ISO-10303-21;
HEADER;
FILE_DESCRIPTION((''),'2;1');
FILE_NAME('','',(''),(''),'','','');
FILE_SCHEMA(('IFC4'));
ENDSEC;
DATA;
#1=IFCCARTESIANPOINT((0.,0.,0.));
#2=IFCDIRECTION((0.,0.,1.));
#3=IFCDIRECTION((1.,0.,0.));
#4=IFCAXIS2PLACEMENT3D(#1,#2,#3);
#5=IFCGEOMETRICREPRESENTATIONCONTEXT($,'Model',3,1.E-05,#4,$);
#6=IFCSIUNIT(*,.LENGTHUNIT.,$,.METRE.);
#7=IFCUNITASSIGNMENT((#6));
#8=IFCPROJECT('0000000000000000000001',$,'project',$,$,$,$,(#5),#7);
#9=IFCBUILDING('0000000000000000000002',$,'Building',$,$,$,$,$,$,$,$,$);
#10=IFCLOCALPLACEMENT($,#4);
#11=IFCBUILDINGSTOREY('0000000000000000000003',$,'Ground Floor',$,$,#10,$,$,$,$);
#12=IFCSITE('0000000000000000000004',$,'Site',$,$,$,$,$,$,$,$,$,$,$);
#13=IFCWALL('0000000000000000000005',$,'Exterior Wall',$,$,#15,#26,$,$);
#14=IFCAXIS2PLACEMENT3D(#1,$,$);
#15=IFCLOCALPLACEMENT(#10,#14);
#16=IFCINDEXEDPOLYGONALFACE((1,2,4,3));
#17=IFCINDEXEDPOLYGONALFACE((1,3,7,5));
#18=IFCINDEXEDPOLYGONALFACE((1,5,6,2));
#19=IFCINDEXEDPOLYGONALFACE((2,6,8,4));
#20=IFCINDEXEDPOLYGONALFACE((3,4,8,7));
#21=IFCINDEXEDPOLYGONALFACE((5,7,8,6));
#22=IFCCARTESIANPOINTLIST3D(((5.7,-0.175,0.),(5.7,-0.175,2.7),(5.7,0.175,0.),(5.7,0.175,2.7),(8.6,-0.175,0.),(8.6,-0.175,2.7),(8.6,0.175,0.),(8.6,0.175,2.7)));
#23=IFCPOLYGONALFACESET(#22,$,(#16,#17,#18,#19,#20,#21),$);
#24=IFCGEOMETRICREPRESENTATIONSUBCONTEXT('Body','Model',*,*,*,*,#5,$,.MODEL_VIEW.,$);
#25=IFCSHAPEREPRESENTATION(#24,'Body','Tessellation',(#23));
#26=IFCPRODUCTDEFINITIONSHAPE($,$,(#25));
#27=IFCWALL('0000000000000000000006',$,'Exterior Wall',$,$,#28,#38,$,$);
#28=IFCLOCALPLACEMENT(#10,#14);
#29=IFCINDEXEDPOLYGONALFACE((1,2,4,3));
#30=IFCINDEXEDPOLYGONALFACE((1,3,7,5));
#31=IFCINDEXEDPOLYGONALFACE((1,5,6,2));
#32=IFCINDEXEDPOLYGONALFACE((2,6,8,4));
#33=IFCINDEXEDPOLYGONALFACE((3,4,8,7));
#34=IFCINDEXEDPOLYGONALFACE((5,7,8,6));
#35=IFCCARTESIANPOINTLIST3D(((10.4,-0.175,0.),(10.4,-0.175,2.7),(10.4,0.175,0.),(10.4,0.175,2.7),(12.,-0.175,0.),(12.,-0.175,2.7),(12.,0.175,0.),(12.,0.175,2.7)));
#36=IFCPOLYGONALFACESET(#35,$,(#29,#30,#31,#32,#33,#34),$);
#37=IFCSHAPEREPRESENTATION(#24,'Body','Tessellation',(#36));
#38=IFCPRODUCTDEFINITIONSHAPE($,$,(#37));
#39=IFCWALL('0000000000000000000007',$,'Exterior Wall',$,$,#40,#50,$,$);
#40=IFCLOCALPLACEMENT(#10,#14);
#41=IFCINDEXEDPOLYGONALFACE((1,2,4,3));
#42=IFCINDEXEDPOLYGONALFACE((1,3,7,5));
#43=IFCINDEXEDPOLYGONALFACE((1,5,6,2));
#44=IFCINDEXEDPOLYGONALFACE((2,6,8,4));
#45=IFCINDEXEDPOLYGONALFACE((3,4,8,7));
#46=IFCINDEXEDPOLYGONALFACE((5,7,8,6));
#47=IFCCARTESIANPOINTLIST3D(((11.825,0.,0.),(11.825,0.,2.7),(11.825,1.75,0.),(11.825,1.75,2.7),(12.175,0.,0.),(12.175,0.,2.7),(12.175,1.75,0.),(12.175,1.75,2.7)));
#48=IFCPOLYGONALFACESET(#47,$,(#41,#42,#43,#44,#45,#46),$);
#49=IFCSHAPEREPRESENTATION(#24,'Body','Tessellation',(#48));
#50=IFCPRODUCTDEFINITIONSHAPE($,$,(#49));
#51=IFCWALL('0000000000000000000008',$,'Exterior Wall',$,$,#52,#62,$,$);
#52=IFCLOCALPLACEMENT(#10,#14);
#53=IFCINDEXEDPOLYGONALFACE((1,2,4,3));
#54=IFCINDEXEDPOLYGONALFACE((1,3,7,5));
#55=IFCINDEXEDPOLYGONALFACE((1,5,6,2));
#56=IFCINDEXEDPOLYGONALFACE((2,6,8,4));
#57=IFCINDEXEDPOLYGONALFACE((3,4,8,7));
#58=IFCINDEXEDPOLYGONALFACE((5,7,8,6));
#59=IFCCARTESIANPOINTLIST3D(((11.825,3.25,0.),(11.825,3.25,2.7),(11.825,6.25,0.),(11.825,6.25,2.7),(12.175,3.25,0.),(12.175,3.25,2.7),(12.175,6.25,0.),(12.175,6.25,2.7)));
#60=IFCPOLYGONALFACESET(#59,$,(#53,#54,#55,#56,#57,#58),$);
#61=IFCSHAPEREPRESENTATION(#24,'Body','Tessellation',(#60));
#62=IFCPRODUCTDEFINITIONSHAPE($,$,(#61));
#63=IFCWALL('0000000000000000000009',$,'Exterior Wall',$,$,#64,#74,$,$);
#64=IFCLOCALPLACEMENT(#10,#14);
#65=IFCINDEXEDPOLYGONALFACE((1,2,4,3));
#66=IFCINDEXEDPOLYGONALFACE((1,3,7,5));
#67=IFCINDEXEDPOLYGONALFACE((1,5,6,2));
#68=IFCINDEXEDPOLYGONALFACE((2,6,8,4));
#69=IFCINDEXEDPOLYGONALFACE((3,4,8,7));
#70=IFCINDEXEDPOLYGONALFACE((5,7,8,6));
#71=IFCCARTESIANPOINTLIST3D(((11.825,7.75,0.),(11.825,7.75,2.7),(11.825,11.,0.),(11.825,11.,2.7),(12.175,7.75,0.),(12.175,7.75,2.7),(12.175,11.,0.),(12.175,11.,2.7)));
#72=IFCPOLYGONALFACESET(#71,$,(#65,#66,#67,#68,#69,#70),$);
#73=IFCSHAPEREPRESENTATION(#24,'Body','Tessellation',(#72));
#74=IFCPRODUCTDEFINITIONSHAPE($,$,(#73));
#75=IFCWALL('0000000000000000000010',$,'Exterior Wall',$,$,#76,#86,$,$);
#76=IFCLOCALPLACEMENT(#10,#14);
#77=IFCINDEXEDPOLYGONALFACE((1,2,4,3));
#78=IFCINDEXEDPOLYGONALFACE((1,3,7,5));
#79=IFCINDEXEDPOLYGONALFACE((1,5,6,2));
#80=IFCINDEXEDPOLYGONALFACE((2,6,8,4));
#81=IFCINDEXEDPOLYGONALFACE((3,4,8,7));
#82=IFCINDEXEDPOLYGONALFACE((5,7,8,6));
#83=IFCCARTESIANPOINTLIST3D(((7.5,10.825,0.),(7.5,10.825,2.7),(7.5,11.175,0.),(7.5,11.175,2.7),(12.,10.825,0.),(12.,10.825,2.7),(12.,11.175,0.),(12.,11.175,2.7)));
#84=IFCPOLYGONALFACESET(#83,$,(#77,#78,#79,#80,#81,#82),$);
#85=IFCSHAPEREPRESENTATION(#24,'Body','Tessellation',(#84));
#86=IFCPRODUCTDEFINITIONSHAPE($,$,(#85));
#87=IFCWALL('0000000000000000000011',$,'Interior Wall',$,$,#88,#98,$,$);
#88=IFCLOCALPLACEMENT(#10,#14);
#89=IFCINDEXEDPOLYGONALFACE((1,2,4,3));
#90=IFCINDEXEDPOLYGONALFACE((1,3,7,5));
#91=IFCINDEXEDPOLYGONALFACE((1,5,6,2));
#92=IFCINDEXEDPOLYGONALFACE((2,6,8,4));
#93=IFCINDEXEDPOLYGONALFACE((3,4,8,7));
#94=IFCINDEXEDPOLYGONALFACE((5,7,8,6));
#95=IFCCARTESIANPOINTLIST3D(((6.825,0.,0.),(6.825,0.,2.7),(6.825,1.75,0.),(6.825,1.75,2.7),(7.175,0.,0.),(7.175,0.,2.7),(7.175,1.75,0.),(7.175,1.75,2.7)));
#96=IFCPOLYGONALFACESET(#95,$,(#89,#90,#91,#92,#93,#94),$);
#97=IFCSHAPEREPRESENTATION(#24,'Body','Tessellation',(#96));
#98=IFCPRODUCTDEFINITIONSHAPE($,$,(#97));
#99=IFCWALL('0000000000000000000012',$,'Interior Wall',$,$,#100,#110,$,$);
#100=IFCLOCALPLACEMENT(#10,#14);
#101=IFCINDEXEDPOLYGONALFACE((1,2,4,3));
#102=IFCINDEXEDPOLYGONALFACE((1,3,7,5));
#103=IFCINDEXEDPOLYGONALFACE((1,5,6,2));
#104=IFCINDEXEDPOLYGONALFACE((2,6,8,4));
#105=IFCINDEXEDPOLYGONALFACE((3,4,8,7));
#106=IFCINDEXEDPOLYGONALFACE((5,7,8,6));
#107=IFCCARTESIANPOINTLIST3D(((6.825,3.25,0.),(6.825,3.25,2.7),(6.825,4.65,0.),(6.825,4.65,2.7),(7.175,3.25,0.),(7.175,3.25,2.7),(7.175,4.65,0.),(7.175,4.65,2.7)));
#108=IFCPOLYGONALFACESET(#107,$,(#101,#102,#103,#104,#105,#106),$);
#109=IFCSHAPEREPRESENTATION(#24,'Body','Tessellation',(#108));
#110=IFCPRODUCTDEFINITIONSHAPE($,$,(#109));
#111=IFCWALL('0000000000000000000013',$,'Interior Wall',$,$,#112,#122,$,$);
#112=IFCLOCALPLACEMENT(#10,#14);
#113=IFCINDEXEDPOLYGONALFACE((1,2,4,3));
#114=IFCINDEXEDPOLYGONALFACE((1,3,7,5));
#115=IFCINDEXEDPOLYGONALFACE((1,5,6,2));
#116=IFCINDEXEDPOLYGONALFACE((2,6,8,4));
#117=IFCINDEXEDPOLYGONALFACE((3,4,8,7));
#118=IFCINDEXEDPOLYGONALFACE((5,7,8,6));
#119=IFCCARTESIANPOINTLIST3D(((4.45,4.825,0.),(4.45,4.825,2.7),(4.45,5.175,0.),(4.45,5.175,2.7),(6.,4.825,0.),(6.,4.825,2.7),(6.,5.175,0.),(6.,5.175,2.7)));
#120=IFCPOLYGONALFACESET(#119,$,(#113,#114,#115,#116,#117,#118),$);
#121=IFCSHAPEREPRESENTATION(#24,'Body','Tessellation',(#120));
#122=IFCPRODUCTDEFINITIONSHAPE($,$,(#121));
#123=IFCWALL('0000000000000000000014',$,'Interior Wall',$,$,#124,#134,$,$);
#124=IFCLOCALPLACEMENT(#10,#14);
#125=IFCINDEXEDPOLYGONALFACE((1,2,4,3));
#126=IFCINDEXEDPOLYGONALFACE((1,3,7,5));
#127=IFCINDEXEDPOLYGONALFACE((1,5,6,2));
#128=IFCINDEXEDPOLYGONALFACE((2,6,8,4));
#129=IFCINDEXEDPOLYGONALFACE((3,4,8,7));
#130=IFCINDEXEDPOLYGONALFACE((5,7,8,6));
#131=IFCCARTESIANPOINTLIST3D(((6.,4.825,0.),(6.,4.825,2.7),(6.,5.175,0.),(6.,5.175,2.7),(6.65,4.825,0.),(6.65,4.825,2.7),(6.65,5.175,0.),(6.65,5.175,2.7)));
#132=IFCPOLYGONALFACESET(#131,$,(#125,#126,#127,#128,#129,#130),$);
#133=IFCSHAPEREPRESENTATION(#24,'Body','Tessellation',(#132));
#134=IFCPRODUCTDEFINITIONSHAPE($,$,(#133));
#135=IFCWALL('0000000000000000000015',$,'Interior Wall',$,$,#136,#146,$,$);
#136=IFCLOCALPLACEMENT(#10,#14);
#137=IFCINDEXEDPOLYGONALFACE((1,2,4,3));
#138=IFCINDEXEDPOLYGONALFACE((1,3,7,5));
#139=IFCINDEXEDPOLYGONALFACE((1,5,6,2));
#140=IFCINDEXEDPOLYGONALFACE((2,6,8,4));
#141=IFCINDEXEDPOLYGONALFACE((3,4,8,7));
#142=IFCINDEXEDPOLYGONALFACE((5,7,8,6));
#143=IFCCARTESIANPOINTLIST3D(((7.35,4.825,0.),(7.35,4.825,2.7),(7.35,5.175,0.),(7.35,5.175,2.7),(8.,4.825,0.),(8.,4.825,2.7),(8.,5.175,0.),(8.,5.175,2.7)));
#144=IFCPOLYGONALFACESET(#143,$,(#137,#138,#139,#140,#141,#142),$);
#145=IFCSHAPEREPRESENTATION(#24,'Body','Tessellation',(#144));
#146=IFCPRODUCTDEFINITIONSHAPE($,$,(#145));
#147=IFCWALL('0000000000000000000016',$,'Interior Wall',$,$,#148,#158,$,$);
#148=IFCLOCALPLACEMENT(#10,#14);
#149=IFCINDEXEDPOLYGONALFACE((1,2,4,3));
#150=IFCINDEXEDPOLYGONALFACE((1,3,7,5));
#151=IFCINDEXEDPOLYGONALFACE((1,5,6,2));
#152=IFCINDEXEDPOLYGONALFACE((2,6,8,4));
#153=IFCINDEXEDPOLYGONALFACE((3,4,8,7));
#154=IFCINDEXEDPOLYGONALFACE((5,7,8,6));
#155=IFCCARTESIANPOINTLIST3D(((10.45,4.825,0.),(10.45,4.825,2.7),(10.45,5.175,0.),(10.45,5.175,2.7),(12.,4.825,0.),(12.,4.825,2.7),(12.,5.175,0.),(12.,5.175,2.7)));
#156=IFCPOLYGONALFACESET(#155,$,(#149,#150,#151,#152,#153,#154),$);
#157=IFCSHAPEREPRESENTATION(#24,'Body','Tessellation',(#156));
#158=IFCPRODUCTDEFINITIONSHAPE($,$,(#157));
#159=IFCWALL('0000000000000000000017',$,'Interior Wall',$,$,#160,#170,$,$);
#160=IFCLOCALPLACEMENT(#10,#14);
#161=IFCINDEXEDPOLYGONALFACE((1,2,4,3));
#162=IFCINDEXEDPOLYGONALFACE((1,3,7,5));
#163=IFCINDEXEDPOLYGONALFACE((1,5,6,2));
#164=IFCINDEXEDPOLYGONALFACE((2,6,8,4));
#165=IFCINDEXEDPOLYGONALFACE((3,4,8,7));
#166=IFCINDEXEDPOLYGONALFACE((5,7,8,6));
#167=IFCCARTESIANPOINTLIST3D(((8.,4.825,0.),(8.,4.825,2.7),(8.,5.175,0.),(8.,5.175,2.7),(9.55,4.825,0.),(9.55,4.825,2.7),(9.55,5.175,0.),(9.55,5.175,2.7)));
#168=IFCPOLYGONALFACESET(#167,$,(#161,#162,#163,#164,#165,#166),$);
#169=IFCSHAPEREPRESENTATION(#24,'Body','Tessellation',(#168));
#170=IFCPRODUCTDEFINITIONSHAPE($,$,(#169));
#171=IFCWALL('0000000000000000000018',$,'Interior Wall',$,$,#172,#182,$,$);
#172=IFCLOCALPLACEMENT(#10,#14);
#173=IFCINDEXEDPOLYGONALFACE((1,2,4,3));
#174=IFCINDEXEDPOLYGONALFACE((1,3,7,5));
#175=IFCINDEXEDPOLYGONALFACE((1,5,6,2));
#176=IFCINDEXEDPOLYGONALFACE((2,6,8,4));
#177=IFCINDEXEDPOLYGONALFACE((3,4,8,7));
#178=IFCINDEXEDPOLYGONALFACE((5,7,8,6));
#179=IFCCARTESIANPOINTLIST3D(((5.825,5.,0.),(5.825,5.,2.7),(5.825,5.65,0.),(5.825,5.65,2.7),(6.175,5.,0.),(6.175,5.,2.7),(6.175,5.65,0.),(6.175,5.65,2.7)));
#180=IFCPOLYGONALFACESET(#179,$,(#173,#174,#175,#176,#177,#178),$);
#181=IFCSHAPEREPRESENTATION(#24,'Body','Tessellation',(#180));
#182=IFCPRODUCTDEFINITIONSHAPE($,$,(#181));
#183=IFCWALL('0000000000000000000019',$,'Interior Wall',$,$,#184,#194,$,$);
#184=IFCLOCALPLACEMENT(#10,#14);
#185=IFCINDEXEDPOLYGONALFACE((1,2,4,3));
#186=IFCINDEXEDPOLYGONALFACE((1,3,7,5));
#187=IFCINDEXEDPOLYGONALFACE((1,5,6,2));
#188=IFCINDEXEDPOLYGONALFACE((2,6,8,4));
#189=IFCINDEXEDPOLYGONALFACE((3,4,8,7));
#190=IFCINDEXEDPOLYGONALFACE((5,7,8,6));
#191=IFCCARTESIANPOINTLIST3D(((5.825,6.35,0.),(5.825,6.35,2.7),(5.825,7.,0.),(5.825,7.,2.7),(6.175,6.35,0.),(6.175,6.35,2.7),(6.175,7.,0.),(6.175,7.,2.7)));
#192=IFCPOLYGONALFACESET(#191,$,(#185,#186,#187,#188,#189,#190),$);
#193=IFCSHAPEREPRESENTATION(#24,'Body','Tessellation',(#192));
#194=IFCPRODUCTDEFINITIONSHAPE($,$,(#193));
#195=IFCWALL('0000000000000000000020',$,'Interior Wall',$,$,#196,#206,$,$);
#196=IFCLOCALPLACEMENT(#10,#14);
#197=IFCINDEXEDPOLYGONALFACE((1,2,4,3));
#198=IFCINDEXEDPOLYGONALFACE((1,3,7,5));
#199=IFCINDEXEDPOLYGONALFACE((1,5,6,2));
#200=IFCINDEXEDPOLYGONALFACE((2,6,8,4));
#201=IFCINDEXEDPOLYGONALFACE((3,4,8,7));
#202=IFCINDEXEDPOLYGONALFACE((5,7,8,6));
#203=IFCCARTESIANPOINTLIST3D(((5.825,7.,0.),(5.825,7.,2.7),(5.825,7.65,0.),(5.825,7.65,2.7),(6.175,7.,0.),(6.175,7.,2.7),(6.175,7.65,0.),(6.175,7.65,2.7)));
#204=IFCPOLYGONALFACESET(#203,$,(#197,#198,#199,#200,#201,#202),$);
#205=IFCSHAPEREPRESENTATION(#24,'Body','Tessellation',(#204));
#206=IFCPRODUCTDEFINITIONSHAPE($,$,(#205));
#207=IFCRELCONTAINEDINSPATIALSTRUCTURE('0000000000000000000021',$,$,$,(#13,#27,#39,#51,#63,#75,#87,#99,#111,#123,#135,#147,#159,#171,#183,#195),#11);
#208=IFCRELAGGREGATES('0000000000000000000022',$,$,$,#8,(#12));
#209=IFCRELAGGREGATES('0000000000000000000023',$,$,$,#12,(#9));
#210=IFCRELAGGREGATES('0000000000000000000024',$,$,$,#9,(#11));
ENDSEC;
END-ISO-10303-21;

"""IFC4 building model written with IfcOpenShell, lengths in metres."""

from ifc_helpers import new_model, si_unit, frame, origin_with_axes, place, context, subcontext, project, spatial, indexed_curve, outline, extrude, element, save


model = new_model("IFC4")

# Units and contexts
model_context = context("Model", 3, precision=1e-05, world=origin_with_axes())
body_context = subcontext(model_context, "Body", "Model", "MODEL_VIEW")
ifc_project = project(units=[si_unit("LENGTHUNIT", "METRE")], contexts=[model_context])

# Site, building, storey
site = spatial("IfcSite", under=ifc_project, Name="Site")
building = spatial("IfcBuilding", under=site, Name="Building")
storey_placement = place(None, origin_with_axes())
storey = spatial("IfcBuildingStorey", under=building, at=storey_placement, Name="Ground Floor")

# Walls
wall_1_placement = place(storey_placement, frame((5.7, 0.0, 0.0), z_axis=(0.0, 0.0, 1.0), x_axis=(1.0, 0.0, 0.0)))
element("IfcWall", 1, at=wall_1_placement, inside=storey, Name="Exterior Wall", context=body_context, shape_type="SweptSolid", body=[
    extrude(outline(indexed_curve([(0.0, 0.0), (0.0, 0.35), (2.9, 0.35), (2.9, 0.0), (0.0, 0.0)], self_intersect=False)), frame((0.0, -0.175, 0.0), z_axis=(0.0, 0.0, 1.0), x_axis=(1.0, 0.0, 0.0)), (0.0, 0.0, 1.0), 2.7),
])
wall_2_placement = place(storey_placement, frame((10.4, 0.0, 0.0), z_axis=(0.0, 0.0, 1.0), x_axis=(1.0, 0.0, 0.0)))
element("IfcWall", 2, at=wall_2_placement, inside=storey, Name="Exterior Wall", context=body_context, shape_type="SweptSolid", body=[
    extrude(outline(indexed_curve([(0.0, 0.0), (0.0, 0.35), (1.6, 0.35), (1.6, 0.0), (0.0, 0.0)], self_intersect=False)), frame((0.0, -0.175, 0.0), z_axis=(0.0, 0.0, 1.0), x_axis=(1.0, 0.0, 0.0)), (0.0, 0.0, 1.0), 2.7),
])
wall_3_placement = place(storey_placement, frame((12.0, 0.0, 0.0), z_axis=(0.0, 0.0, 1.0), x_axis=(0.0, 1.0, 0.0)))
element("IfcWall", 3, at=wall_3_placement, inside=storey, Name="Exterior Wall", context=body_context, shape_type="SweptSolid", body=[
    extrude(outline(indexed_curve([(0.0, 0.0), (0.0, 0.35), (1.75, 0.35), (1.75, 0.0), (0.0, 0.0)], self_intersect=False)), frame((0.0, -0.175, 0.0), z_axis=(0.0, 0.0, 1.0), x_axis=(1.0, 0.0, 0.0)), (0.0, 0.0, 1.0), 2.7),
])
wall_4_placement = place(storey_placement, frame((12.0, 3.25, 0.0), z_axis=(0.0, 0.0, 1.0), x_axis=(0.0, 1.0, 0.0)))
element("IfcWall", 4, at=wall_4_placement, inside=storey, Name="Exterior Wall", context=body_context, shape_type="SweptSolid", body=[
    extrude(outline(indexed_curve([(0.0, 0.0), (0.0, 0.35), (3.0, 0.35), (3.0, 0.0), (0.0, 0.0)], self_intersect=False)), frame((0.0, -0.175, 0.0), z_axis=(0.0, 0.0, 1.0), x_axis=(1.0, 0.0, 0.0)), (0.0, 0.0, 1.0), 2.7),
])
wall_5_placement = place(storey_placement, frame((12.0, 7.75, 0.0), z_axis=(0.0, 0.0, 1.0), x_axis=(0.0, 1.0, 0.0)))
element("IfcWall", 5, at=wall_5_placement, inside=storey, Name="Exterior Wall", context=body_context, shape_type="SweptSolid", body=[
    extrude(outline(indexed_curve([(0.0, 0.0), (0.0, 0.35), (3.25, 0.35), (3.25, 0.0), (0.0, 0.0)], self_intersect=False)), frame((0.0, -0.175, 0.0), z_axis=(0.0, 0.0, 1.0), x_axis=(1.0, 0.0, 0.0)), (0.0, 0.0, 1.0), 2.7),
])
wall_6_placement = place(storey_placement, frame((12.0, 11.0, 0.0), z_axis=(0.0, 0.0, 1.0), x_axis=(-1.0, 0.0, 0.0)))
element("IfcWall", 6, at=wall_6_placement, inside=storey, Name="Exterior Wall", context=body_context, shape_type="SweptSolid", body=[
    extrude(outline(indexed_curve([(0.0, 0.0), (0.0, 0.35), (4.5, 0.35), (4.5, 0.0), (0.0, 0.0)], self_intersect=False)), frame((0.0, -0.175, 0.0), z_axis=(0.0, 0.0, 1.0), x_axis=(1.0, 0.0, 0.0)), (0.0, 0.0, 1.0), 2.7),
])
wall_7_placement = place(storey_placement, frame((7.0, 0.0, 0.0), z_axis=(0.0, 0.0, 1.0), x_axis=(0.0, 1.0, 0.0)))
element("IfcWall", 7, at=wall_7_placement, inside=storey, Name="Interior Wall", context=body_context, shape_type="SweptSolid", body=[
    extrude(outline(indexed_curve([(0.0, 0.0), (0.0, 0.35), (1.75, 0.35), (1.75, 0.0), (0.0, 0.0)], self_intersect=False)), frame((0.0, -0.175, 0.0), z_axis=(0.0, 0.0, 1.0), x_axis=(1.0, 0.0, 0.0)), (0.0, 0.0, 1.0), 2.7),
])
wall_8_placement = place(storey_placement, frame((7.0, 3.25, 0.0), z_axis=(0.0, 0.0, 1.0), x_axis=(0.0, 1.0, 0.0)))
element("IfcWall", 8, at=wall_8_placement, inside=storey, Name="Interior Wall", context=body_context, shape_type="SweptSolid", body=[
    extrude(outline(indexed_curve([(0.0, 0.0), (0.0, 0.35), (1.4, 0.35), (1.4, 0.0), (0.0, 0.0)], self_intersect=False)), frame((0.0, -0.175, 0.0), z_axis=(0.0, 0.0, 1.0), x_axis=(1.0, 0.0, 0.0)), (0.0, 0.0, 1.0), 2.7),
])
wall_9_placement = place(storey_placement, frame((6.0, 5.0, 0.0), z_axis=(0.0, 0.0, 1.0), x_axis=(-1.0, 0.0, 0.0)))
element("IfcWall", 9, at=wall_9_placement, inside=storey, Name="Interior Wall", context=body_context, shape_type="SweptSolid", body=[
    extrude(outline(indexed_curve([(0.0, 0.0), (0.0, 0.35), (1.55, 0.35), (1.55, 0.0), (0.0, 0.0)], self_intersect=False)), frame((0.0, -0.175, 0.0), z_axis=(0.0, 0.0, 1.0), x_axis=(1.0, 0.0, 0.0)), (0.0, 0.0, 1.0), 2.7),
])
for number, where, z_axis, x_axis, name in (
    (10, (6.65, 5.0, 0.0), (0.0, 0.0, 1.0), (-1.0, 0.0, 0.0), "Interior Wall"),
    (11, (8.0, 5.0, 0.0), (0.0, 0.0, 1.0), (-1.0, 0.0, 0.0), "Interior Wall"),
):
    element("IfcWall", number, at=place(storey_placement, frame(where, z_axis=z_axis, x_axis=x_axis)), inside=storey, Name=name, context=body_context, shape_type="SweptSolid", body=[
        extrude(outline(indexed_curve([(0.0, 0.0), (0.0, 0.35), (0.65, 0.35), (0.65, 0.0), (0.0, 0.0)], self_intersect=False)), frame((0.0, -0.175, 0.0), z_axis=(0.0, 0.0, 1.0), x_axis=(1.0, 0.0, 0.0)), (0.0, 0.0, 1.0), 2.7),
    ])
for number, where, z_axis, x_axis, name in (
    (12, (12.0, 5.0, 0.0), (0.0, 0.0, 1.0), (-1.0, 0.0, 0.0), "Interior Wall"),
    (13, (9.55, 5.0, 0.0), (0.0, 0.0, 1.0), (-1.0, 0.0, 0.0), "Interior Wall"),
):
    element("IfcWall", number, at=place(storey_placement, frame(where, z_axis=z_axis, x_axis=x_axis)), inside=storey, Name=name, context=body_context, shape_type="SweptSolid", body=[
        extrude(outline(indexed_curve([(0.0, 0.0), (0.0, 0.35), (1.55, 0.35), (1.55, 0.0), (0.0, 0.0)], self_intersect=False)), frame((0.0, -0.175, 0.0), z_axis=(0.0, 0.0, 1.0), x_axis=(1.0, 0.0, 0.0)), (0.0, 0.0, 1.0), 2.7),
    ])
for number, where, z_axis, x_axis, name in (
    (14, (6.0, 5.0, 0.0), (0.0, 0.0, 1.0), (0.0, 1.0, 0.0), "Interior Wall"),
    (15, (6.0, 6.35, 0.0), (0.0, 0.0, 1.0), (0.0, 1.0, 0.0), "Interior Wall"),
    (16, (6.0, 7.0, 0.0), (0.0, 0.0, 1.0), (0.0, 1.0, 0.0), "Interior Wall"),
):
    element("IfcWall", number, at=place(storey_placement, frame(where, z_axis=z_axis, x_axis=x_axis)), inside=storey, Name=name, context=body_context, shape_type="SweptSolid", body=[
        extrude(outline(indexed_curve([(0.0, 0.0), (0.0, 0.35), (0.65, 0.35), (0.65, 0.0), (0.0, 0.0)], self_intersect=False)), frame((0.0, -0.175, 0.0), z_axis=(0.0, 0.0, 1.0), x_axis=(1.0, 0.0, 0.0)), (0.0, 0.0, 1.0), 2.7),
    ])

save(model, "model.ifc")
